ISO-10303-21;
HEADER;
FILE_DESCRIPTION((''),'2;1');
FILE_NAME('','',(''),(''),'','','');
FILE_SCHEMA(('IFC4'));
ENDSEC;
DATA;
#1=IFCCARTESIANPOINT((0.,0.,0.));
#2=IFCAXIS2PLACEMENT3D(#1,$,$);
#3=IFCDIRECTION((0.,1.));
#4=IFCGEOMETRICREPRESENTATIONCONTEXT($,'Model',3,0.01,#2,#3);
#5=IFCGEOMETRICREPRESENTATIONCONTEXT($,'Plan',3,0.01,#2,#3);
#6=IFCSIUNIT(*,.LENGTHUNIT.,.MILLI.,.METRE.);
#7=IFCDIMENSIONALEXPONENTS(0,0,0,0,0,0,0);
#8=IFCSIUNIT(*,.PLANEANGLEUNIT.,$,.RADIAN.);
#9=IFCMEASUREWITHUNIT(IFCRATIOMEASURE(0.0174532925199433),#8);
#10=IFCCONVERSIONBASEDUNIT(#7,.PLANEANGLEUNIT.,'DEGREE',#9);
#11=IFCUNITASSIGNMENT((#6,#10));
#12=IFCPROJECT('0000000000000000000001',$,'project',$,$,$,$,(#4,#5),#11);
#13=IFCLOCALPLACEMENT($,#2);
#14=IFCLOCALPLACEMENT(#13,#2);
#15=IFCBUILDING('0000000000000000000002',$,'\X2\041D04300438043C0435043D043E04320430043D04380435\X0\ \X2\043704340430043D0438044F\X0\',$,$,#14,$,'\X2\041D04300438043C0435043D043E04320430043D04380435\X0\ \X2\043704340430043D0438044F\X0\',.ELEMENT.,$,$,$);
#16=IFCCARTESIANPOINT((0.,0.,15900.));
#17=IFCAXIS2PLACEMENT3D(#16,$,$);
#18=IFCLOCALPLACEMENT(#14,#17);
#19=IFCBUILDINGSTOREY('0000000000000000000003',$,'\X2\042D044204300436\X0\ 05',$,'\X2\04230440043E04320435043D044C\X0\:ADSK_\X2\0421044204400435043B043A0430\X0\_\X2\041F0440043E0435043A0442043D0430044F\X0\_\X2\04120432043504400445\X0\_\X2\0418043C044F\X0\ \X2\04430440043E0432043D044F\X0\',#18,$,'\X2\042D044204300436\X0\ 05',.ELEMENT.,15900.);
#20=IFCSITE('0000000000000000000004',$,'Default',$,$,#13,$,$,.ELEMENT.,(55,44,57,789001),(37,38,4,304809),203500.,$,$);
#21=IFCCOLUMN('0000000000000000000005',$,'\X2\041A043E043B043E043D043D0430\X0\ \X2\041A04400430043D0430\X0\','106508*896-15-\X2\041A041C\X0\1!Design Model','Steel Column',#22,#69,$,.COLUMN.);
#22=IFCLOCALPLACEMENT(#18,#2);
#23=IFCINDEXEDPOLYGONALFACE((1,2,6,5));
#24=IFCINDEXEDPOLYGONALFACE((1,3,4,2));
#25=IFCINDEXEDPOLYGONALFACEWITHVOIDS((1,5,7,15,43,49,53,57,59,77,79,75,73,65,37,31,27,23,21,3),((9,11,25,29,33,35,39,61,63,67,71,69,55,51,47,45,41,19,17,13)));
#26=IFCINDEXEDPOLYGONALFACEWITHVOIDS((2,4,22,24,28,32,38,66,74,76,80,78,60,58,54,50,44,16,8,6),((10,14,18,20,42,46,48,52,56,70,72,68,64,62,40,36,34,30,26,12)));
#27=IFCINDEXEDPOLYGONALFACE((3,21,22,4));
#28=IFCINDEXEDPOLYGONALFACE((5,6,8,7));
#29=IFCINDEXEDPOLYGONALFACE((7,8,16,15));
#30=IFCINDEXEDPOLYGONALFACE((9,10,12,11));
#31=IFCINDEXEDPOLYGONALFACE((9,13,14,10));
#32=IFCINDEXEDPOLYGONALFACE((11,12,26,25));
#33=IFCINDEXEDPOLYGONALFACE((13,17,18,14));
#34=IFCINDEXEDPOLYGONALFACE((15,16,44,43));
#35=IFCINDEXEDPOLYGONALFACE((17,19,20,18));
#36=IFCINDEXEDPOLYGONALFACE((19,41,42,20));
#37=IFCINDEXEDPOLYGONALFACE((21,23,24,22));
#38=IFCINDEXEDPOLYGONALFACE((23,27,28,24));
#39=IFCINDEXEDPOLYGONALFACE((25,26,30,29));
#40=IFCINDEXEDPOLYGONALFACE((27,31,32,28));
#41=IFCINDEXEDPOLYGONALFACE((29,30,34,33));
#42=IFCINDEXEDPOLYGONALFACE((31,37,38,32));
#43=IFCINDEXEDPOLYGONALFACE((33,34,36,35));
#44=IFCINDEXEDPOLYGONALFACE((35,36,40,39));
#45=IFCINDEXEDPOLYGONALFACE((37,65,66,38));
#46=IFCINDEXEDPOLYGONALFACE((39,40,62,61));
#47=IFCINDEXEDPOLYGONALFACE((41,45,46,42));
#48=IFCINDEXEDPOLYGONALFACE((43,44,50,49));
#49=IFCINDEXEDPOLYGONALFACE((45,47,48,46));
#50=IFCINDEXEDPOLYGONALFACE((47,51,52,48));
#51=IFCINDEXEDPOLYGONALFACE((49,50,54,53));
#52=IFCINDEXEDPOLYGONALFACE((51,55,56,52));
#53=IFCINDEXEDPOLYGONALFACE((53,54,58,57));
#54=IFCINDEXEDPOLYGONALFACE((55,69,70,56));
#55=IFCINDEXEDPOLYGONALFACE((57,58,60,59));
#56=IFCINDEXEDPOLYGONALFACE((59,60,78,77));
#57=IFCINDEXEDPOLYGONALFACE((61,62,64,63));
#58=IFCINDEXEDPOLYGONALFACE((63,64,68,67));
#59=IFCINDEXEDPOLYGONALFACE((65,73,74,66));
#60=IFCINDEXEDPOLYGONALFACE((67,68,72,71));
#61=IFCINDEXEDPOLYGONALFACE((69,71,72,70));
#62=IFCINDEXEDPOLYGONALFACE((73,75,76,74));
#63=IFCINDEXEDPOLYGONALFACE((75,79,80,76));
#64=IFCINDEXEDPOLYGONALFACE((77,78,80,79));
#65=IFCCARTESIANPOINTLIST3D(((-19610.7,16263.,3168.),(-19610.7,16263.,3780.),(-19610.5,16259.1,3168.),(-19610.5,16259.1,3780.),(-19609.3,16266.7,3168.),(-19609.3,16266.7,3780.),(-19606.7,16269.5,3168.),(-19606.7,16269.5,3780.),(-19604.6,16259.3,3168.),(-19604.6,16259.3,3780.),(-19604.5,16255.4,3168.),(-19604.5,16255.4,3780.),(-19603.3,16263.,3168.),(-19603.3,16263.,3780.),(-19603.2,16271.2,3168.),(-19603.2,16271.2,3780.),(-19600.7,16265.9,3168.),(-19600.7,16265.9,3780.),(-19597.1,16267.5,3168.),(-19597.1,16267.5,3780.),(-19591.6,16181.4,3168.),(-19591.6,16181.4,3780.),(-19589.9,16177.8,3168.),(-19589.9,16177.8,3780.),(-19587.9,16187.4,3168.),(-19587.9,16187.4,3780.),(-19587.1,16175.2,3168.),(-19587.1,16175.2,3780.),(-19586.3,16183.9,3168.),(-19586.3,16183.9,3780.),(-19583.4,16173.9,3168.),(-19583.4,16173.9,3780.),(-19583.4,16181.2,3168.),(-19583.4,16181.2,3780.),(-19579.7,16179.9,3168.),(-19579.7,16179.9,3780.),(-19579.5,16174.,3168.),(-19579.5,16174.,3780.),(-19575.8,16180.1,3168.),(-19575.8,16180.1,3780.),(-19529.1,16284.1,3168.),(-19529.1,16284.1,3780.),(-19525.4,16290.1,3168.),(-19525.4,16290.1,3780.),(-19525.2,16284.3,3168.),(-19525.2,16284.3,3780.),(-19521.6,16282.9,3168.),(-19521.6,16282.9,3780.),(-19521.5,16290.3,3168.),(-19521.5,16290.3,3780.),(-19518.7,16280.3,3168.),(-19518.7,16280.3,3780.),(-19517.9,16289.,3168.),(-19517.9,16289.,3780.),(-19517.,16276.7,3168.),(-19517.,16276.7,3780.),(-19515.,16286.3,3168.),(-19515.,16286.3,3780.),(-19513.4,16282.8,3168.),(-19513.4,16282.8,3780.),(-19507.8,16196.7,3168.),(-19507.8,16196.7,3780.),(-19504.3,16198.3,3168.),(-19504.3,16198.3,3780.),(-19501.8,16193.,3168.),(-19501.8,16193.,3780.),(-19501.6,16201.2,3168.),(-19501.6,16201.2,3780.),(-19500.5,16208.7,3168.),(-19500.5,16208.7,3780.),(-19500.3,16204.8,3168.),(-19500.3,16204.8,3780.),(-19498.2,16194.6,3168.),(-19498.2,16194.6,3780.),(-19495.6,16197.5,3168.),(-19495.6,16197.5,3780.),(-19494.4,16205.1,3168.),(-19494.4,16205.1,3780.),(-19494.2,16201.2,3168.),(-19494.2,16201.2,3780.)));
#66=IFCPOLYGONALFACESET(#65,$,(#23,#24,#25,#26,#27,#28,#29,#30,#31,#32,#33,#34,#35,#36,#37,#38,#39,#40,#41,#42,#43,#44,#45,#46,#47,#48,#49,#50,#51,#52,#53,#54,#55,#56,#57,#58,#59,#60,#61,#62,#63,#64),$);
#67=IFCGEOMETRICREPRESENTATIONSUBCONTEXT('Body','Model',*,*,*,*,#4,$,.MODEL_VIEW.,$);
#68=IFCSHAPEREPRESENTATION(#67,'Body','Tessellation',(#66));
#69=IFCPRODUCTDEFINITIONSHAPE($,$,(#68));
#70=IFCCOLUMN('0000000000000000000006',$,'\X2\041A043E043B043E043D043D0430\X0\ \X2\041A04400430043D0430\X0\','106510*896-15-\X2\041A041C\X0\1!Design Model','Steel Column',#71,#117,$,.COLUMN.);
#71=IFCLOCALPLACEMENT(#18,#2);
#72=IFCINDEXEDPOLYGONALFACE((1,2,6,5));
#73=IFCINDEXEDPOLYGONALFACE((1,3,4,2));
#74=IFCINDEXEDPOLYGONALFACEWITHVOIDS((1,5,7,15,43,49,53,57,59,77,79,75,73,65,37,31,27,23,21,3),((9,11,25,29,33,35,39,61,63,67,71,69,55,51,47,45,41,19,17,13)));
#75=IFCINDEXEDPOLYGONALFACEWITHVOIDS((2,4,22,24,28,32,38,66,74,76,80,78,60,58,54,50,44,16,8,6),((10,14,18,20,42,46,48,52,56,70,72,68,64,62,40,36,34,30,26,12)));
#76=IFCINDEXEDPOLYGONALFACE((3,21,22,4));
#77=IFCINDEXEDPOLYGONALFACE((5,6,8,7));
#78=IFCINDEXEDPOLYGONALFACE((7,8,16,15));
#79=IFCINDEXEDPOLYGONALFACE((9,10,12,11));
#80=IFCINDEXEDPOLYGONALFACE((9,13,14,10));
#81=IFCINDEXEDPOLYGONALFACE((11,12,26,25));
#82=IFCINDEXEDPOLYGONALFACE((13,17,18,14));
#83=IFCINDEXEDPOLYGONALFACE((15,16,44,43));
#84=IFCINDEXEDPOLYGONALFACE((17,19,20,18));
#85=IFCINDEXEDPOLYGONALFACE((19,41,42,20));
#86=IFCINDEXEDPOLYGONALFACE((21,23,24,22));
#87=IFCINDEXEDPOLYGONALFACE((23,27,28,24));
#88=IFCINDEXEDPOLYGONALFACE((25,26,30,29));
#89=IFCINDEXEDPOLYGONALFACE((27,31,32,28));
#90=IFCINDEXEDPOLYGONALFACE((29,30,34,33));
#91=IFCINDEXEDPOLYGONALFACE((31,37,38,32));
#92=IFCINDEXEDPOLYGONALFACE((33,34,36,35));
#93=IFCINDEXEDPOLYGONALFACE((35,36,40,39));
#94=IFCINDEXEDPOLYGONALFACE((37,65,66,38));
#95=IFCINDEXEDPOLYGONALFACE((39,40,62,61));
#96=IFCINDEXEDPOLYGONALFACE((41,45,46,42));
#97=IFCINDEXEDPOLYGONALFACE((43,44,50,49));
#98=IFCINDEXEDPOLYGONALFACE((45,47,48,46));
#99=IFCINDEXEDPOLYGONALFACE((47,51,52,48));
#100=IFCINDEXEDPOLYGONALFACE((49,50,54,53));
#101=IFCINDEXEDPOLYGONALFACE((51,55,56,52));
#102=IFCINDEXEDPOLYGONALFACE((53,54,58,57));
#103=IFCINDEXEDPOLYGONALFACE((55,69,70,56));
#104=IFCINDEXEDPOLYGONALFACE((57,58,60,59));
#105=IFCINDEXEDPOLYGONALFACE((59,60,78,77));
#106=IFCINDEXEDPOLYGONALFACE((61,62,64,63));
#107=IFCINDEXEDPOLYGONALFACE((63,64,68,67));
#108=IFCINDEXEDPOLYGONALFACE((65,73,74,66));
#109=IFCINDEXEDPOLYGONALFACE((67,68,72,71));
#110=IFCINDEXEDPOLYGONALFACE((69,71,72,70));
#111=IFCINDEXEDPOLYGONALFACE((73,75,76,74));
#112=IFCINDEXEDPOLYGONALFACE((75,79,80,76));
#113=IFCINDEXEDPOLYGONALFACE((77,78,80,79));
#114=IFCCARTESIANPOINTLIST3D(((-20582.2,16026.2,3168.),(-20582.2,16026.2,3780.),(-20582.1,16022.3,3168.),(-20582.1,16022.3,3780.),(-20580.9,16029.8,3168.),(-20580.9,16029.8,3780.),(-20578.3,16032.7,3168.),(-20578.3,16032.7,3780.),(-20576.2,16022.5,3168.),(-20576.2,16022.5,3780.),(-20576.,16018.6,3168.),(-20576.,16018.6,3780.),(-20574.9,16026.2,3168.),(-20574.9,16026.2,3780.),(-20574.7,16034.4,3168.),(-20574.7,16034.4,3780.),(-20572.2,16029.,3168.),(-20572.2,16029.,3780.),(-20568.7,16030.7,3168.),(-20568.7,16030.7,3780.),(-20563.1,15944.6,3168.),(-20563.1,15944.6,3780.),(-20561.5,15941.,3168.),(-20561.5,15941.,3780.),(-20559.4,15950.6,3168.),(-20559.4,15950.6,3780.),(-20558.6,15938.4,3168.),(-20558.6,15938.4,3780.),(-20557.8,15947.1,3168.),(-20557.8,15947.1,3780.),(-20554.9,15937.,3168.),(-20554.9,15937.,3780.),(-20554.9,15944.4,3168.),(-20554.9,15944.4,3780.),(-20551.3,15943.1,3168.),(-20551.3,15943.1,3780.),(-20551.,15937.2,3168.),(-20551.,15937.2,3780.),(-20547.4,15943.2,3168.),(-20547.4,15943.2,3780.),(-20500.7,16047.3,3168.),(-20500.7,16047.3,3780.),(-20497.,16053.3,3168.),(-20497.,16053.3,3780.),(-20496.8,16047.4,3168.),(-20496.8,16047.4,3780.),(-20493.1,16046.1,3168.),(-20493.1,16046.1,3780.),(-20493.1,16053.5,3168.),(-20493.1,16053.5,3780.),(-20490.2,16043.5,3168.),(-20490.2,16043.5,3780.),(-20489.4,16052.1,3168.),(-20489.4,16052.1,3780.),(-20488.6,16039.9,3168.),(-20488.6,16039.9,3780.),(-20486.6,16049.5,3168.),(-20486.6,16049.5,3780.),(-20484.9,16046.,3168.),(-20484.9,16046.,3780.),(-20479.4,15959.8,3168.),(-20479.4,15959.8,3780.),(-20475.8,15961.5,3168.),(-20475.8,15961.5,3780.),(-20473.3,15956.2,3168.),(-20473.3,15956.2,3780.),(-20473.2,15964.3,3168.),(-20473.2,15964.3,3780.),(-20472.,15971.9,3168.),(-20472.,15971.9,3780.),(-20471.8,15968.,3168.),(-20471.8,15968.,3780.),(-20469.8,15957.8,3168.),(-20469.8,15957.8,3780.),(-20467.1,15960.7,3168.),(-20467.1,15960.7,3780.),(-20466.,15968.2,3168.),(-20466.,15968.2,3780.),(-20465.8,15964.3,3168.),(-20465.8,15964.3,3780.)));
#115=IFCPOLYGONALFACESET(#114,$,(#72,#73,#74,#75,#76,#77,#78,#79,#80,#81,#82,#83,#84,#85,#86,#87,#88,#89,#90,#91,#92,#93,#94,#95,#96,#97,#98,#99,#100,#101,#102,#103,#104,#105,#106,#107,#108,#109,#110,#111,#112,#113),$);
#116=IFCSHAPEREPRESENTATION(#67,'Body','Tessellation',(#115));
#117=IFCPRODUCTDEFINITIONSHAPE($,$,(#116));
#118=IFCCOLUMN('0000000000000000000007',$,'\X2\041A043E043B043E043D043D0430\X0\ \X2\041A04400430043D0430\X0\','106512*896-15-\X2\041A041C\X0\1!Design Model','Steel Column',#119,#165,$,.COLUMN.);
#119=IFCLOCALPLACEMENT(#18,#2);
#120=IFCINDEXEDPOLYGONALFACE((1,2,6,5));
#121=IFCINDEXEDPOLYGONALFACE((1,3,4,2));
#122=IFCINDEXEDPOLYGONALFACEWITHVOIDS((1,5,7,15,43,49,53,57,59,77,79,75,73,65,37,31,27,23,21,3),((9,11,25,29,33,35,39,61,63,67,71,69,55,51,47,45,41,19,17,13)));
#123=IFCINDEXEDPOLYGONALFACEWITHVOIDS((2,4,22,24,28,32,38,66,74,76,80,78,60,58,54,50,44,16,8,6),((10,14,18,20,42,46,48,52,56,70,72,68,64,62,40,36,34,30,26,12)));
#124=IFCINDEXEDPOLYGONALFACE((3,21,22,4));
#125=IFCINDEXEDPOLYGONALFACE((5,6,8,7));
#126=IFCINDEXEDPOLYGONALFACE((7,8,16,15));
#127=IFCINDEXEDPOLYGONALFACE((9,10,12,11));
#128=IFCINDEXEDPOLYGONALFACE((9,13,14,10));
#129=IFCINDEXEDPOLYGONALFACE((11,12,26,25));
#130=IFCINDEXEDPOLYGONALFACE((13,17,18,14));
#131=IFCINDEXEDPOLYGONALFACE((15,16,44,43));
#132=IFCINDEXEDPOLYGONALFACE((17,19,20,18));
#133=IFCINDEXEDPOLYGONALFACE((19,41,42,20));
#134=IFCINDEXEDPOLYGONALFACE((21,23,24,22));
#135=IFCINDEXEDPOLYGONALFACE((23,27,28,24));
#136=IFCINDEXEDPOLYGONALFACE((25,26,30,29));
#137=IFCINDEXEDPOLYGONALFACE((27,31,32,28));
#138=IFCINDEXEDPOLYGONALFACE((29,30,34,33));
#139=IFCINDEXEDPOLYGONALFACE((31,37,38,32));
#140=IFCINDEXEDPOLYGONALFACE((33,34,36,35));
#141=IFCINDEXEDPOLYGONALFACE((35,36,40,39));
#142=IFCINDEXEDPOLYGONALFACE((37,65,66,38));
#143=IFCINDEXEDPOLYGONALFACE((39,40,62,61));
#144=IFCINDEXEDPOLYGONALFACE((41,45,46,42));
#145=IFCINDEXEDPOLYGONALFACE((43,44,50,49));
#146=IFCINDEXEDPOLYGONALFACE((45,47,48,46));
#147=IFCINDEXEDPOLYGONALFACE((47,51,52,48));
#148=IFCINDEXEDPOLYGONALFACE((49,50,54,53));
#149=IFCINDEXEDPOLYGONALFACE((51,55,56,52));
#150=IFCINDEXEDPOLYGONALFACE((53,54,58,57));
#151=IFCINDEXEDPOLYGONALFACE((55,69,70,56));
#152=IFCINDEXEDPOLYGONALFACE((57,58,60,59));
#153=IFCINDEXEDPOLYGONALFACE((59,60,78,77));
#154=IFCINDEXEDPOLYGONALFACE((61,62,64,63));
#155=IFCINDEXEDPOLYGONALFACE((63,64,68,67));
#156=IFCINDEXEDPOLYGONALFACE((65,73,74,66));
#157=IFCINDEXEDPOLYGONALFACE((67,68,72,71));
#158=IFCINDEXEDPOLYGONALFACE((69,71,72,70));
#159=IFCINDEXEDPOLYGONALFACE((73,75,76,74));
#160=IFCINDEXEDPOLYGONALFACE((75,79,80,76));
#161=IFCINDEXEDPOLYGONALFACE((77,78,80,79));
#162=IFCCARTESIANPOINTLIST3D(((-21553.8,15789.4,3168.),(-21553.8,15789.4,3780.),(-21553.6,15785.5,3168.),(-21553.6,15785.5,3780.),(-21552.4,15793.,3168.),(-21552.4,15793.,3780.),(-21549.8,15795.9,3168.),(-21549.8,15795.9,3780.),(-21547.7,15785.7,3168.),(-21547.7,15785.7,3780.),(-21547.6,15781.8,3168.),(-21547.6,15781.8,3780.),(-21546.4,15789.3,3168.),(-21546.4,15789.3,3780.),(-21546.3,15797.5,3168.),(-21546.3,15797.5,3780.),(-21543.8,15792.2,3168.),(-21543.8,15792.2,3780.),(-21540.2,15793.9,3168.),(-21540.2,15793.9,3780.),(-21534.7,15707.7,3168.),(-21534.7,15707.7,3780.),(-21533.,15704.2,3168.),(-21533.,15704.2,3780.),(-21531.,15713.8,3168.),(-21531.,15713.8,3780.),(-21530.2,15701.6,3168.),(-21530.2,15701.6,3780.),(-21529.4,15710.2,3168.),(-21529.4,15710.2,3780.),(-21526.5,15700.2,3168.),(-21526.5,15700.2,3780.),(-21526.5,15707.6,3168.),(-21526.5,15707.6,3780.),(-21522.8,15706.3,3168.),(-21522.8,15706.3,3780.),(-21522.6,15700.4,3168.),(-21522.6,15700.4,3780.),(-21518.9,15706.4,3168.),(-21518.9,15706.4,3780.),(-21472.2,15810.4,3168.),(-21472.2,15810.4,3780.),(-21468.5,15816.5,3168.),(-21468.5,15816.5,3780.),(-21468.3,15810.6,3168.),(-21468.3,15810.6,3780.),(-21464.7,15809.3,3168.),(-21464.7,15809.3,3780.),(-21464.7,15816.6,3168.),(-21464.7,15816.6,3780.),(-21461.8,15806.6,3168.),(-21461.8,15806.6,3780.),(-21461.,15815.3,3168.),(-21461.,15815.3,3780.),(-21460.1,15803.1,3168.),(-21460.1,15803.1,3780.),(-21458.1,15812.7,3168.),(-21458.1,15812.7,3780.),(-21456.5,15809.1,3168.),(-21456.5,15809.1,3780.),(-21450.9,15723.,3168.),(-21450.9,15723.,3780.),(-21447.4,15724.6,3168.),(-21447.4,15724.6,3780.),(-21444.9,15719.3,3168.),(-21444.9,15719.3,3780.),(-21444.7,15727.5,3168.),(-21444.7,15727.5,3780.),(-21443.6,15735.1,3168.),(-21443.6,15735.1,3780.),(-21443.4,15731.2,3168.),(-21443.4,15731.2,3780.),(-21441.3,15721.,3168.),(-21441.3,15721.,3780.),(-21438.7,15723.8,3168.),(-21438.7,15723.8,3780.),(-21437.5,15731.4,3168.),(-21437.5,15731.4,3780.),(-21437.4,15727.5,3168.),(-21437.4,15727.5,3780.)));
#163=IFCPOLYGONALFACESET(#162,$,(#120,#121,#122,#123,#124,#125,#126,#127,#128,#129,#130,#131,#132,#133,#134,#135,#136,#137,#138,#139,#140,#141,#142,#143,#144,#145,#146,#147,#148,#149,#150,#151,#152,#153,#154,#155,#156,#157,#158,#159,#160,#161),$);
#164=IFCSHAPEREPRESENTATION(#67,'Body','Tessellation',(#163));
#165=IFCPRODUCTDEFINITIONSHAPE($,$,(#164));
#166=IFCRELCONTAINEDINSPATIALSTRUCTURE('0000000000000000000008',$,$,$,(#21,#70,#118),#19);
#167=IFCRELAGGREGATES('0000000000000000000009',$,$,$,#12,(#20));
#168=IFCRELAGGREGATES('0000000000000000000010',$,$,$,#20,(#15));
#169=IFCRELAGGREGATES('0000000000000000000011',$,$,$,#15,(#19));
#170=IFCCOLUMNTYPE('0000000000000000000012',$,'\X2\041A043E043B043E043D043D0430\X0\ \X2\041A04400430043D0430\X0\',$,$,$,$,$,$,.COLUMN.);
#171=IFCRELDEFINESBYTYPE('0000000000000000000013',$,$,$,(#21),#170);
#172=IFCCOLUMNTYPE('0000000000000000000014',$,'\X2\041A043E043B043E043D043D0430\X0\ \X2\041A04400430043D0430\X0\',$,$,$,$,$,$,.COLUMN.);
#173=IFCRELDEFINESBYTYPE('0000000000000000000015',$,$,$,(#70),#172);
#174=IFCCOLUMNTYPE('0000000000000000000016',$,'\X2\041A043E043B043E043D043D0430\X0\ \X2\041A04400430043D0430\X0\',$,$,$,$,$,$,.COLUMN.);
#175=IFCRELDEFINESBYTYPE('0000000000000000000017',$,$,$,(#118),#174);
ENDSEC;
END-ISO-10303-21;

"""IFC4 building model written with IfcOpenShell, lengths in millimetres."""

from ifc_helpers import new_model, entity, si_unit, converted_unit, direction, frame, origin, place, context, subcontext, project, spatial, indexed_curve, outline, extrude, type_object, element, save


model = new_model("IFC4")

# Units and contexts
model_context = context("Model", 3, precision=0.01, world=origin(), true_north=direction((0.0, 1.0)))
plan_context = context("Plan", 3, precision=0.01, world=origin(), true_north=direction((0.0, 1.0)))
body_context = subcontext(model_context, "Body", "Model", "MODEL_VIEW")
ifc_project = project(units=[si_unit("LENGTHUNIT", "METRE", prefix="MILLI"), converted_unit("PLANEANGLEUNIT", "DEGREE", entity("IfcRatioMeasure", 0.0174532925199433), si_unit("PLANEANGLEUNIT", "RADIAN"), dimensions=[0, 0, 0, 0, 0, 0, 0])], contexts=[model_context, plan_context])

# Site, building, storey
site_placement = place(None, origin())
site = spatial("IfcSite", under=ifc_project, at=site_placement, Name="Default", CompositionType="ELEMENT", RefLatitude=(55, 44, 57, 789001), RefLongitude=(37, 38, 4, 304809), RefElevation=203500.0)
building_placement = place(site_placement, origin())
building = spatial("IfcBuilding", under=site, at=building_placement, Name="Наименование здания", LongName="Наименование здания", CompositionType="ELEMENT")
storey_placement = place(building_placement, frame((0.0, 0.0, 15900.0)))
storey = spatial("IfcBuildingStorey", under=building, at=storey_placement, Name="Этаж 05", ObjectType="Уровень:ADSK_Стрелка_Проектная_Вверх_Имя уровня", LongName="Этаж 05", CompositionType="ELEMENT", Elevation=15900.0)

# Columns
column_type_1 = type_object("IfcColumnType", Name="Колонна Крана", PredefinedType="COLUMN")
column_1_placement = place(storey_placement, origin())
element("IfcColumn", 1, at=column_1_placement, inside=storey, type_object=column_type_1, Name="Колонна Крана", Description="106508*896-15-КМ1!Design Model", ObjectType="Steel Column", PredefinedType="COLUMN", context=body_context, shape_type="SweptSolid", body=[
    extrude(outline(indexed_curve([(29.5, -56.8), (33.4, -56.8), (37.0, -55.3), (39.7, -52.6), (41.2, -49.0), (56.8, 29.5), (56.8, 33.4), (55.3, 37.0), (52.6, 39.7), (49.0, 41.2), (-29.5, 56.8), (-33.4, 56.8), (-37.0, 55.3), (-39.7, 52.6), (-41.2, 49.0), (-56.8, -29.5), (-56.8, -33.4), (-55.3, -37.0), (-52.6, -39.7), (-49.0, -41.2), (29.5, -56.8)], self_intersect=False), holes=[indexed_curve([(-43.1, -37.3), (-46.7, -35.8), (-49.5, -33.1), (-51.0, -29.5), (-51.0, -25.5), (-37.3, 43.1), (-35.8, 46.7), (-33.1, 49.5), (-29.5, 51.0), (-25.5, 51.0), (43.1, 37.3), (46.7, 35.8), (49.5, 33.1), (51.0, 29.5), (51.0, 25.5), (37.3, -43.1), (35.8, -46.7), (33.1, -49.5), (29.5, -51.0), (25.5, -51.0), (-43.1, -37.3)], self_intersect=False)]), frame((-19552.5, 16232.1, 3168.0), z_axis=(0.0, 0.0, 1.0), x_axis=(0.906681, 0.421816, 0.0)), (0.0, 0.0, 1.0), 612.0),
])
column_type_2 = type_object("IfcColumnType", Name="Колонна Крана", PredefinedType="COLUMN")
column_2_placement = place(storey_placement, origin())
element("IfcColumn", 2, at=column_2_placement, inside=storey, type_object=column_type_2, Name="Колонна Крана", Description="106510*896-15-КМ1!Design Model", ObjectType="Steel Column", PredefinedType="COLUMN", context=body_context, shape_type="SweptSolid", body=[
    extrude(outline(indexed_curve([(29.5, -56.8), (33.4, -56.8), (37.0, -55.3), (39.7, -52.6), (41.2, -49.0), (56.8, 29.5), (56.8, 33.4), (55.3, 37.0), (52.6, 39.7), (49.0, 41.2), (-29.5, 56.8), (-33.4, 56.8), (-37.0, 55.3), (-39.7, 52.6), (-41.2, 49.0), (-56.8, -29.5), (-56.8, -33.4), (-55.3, -37.0), (-52.6, -39.7), (-49.0, -41.2), (29.5, -56.8)], self_intersect=False), holes=[indexed_curve([(-43.1, -37.3), (-46.7, -35.8), (-49.5, -33.1), (-51.0, -29.5), (-51.0, -25.5), (-37.3, 43.1), (-35.8, 46.7), (-33.1, 49.5), (-29.5, 51.0), (-25.5, 51.0), (43.1, 37.3), (46.7, 35.8), (49.5, 33.1), (51.0, 29.5), (51.0, 25.5), (37.3, -43.1), (35.8, -46.7), (33.1, -49.5), (29.5, -51.0), (25.5, -51.0), (-43.1, -37.3)], self_intersect=False)]), frame((-20524.0, 15995.3, 3168.0), z_axis=(0.0, 0.0, 1.0), x_axis=(0.906681, 0.421816, 0.0)), (0.0, 0.0, 1.0), 612.0),
])
column_type_3 = type_object("IfcColumnType", Name="Колонна Крана", PredefinedType="COLUMN")
column_3_placement = place(storey_placement, origin())
element("IfcColumn", 3, at=column_3_placement, inside=storey, type_object=column_type_3, Name="Колонна Крана", Description="106512*896-15-КМ1!Design Model", ObjectType="Steel Column", PredefinedType="COLUMN", context=body_context, shape_type="SweptSolid", body=[
    extrude(outline(indexed_curve([(29.5, -56.8), (33.4, -56.8), (37.0, -55.3), (39.7, -52.6), (41.2, -49.0), (56.8, 29.5), (56.8, 33.4), (55.3, 37.0), (52.6, 39.7), (49.0, 41.2), (-29.5, 56.8), (-33.4, 56.8), (-37.0, 55.3), (-39.7, 52.6), (-41.2, 49.0), (-56.8, -29.5), (-56.8, -33.4), (-55.3, -37.0), (-52.6, -39.7), (-49.0, -41.2), (29.5, -56.8)], self_intersect=False), holes=[indexed_curve([(-43.1, -37.3), (-46.7, -35.8), (-49.5, -33.1), (-51.0, -29.5), (-51.0, -25.5), (-37.3, 43.1), (-35.8, 46.7), (-33.1, 49.5), (-29.5, 51.0), (-25.5, 51.0), (43.1, 37.3), (46.7, 35.8), (49.5, 33.1), (51.0, 29.5), (51.0, 25.5), (37.3, -43.1), (35.8, -46.7), (33.1, -49.5), (29.5, -51.0), (25.5, -51.0), (-43.1, -37.3)], self_intersect=False)]), frame((-21495.6, 15758.4, 3168.0), z_axis=(0.0, 0.0, 1.0), x_axis=(0.906681, 0.421816, 0.0)), (0.0, 0.0, 1.0), 612.0),
])

save(model, "model.ifc")
